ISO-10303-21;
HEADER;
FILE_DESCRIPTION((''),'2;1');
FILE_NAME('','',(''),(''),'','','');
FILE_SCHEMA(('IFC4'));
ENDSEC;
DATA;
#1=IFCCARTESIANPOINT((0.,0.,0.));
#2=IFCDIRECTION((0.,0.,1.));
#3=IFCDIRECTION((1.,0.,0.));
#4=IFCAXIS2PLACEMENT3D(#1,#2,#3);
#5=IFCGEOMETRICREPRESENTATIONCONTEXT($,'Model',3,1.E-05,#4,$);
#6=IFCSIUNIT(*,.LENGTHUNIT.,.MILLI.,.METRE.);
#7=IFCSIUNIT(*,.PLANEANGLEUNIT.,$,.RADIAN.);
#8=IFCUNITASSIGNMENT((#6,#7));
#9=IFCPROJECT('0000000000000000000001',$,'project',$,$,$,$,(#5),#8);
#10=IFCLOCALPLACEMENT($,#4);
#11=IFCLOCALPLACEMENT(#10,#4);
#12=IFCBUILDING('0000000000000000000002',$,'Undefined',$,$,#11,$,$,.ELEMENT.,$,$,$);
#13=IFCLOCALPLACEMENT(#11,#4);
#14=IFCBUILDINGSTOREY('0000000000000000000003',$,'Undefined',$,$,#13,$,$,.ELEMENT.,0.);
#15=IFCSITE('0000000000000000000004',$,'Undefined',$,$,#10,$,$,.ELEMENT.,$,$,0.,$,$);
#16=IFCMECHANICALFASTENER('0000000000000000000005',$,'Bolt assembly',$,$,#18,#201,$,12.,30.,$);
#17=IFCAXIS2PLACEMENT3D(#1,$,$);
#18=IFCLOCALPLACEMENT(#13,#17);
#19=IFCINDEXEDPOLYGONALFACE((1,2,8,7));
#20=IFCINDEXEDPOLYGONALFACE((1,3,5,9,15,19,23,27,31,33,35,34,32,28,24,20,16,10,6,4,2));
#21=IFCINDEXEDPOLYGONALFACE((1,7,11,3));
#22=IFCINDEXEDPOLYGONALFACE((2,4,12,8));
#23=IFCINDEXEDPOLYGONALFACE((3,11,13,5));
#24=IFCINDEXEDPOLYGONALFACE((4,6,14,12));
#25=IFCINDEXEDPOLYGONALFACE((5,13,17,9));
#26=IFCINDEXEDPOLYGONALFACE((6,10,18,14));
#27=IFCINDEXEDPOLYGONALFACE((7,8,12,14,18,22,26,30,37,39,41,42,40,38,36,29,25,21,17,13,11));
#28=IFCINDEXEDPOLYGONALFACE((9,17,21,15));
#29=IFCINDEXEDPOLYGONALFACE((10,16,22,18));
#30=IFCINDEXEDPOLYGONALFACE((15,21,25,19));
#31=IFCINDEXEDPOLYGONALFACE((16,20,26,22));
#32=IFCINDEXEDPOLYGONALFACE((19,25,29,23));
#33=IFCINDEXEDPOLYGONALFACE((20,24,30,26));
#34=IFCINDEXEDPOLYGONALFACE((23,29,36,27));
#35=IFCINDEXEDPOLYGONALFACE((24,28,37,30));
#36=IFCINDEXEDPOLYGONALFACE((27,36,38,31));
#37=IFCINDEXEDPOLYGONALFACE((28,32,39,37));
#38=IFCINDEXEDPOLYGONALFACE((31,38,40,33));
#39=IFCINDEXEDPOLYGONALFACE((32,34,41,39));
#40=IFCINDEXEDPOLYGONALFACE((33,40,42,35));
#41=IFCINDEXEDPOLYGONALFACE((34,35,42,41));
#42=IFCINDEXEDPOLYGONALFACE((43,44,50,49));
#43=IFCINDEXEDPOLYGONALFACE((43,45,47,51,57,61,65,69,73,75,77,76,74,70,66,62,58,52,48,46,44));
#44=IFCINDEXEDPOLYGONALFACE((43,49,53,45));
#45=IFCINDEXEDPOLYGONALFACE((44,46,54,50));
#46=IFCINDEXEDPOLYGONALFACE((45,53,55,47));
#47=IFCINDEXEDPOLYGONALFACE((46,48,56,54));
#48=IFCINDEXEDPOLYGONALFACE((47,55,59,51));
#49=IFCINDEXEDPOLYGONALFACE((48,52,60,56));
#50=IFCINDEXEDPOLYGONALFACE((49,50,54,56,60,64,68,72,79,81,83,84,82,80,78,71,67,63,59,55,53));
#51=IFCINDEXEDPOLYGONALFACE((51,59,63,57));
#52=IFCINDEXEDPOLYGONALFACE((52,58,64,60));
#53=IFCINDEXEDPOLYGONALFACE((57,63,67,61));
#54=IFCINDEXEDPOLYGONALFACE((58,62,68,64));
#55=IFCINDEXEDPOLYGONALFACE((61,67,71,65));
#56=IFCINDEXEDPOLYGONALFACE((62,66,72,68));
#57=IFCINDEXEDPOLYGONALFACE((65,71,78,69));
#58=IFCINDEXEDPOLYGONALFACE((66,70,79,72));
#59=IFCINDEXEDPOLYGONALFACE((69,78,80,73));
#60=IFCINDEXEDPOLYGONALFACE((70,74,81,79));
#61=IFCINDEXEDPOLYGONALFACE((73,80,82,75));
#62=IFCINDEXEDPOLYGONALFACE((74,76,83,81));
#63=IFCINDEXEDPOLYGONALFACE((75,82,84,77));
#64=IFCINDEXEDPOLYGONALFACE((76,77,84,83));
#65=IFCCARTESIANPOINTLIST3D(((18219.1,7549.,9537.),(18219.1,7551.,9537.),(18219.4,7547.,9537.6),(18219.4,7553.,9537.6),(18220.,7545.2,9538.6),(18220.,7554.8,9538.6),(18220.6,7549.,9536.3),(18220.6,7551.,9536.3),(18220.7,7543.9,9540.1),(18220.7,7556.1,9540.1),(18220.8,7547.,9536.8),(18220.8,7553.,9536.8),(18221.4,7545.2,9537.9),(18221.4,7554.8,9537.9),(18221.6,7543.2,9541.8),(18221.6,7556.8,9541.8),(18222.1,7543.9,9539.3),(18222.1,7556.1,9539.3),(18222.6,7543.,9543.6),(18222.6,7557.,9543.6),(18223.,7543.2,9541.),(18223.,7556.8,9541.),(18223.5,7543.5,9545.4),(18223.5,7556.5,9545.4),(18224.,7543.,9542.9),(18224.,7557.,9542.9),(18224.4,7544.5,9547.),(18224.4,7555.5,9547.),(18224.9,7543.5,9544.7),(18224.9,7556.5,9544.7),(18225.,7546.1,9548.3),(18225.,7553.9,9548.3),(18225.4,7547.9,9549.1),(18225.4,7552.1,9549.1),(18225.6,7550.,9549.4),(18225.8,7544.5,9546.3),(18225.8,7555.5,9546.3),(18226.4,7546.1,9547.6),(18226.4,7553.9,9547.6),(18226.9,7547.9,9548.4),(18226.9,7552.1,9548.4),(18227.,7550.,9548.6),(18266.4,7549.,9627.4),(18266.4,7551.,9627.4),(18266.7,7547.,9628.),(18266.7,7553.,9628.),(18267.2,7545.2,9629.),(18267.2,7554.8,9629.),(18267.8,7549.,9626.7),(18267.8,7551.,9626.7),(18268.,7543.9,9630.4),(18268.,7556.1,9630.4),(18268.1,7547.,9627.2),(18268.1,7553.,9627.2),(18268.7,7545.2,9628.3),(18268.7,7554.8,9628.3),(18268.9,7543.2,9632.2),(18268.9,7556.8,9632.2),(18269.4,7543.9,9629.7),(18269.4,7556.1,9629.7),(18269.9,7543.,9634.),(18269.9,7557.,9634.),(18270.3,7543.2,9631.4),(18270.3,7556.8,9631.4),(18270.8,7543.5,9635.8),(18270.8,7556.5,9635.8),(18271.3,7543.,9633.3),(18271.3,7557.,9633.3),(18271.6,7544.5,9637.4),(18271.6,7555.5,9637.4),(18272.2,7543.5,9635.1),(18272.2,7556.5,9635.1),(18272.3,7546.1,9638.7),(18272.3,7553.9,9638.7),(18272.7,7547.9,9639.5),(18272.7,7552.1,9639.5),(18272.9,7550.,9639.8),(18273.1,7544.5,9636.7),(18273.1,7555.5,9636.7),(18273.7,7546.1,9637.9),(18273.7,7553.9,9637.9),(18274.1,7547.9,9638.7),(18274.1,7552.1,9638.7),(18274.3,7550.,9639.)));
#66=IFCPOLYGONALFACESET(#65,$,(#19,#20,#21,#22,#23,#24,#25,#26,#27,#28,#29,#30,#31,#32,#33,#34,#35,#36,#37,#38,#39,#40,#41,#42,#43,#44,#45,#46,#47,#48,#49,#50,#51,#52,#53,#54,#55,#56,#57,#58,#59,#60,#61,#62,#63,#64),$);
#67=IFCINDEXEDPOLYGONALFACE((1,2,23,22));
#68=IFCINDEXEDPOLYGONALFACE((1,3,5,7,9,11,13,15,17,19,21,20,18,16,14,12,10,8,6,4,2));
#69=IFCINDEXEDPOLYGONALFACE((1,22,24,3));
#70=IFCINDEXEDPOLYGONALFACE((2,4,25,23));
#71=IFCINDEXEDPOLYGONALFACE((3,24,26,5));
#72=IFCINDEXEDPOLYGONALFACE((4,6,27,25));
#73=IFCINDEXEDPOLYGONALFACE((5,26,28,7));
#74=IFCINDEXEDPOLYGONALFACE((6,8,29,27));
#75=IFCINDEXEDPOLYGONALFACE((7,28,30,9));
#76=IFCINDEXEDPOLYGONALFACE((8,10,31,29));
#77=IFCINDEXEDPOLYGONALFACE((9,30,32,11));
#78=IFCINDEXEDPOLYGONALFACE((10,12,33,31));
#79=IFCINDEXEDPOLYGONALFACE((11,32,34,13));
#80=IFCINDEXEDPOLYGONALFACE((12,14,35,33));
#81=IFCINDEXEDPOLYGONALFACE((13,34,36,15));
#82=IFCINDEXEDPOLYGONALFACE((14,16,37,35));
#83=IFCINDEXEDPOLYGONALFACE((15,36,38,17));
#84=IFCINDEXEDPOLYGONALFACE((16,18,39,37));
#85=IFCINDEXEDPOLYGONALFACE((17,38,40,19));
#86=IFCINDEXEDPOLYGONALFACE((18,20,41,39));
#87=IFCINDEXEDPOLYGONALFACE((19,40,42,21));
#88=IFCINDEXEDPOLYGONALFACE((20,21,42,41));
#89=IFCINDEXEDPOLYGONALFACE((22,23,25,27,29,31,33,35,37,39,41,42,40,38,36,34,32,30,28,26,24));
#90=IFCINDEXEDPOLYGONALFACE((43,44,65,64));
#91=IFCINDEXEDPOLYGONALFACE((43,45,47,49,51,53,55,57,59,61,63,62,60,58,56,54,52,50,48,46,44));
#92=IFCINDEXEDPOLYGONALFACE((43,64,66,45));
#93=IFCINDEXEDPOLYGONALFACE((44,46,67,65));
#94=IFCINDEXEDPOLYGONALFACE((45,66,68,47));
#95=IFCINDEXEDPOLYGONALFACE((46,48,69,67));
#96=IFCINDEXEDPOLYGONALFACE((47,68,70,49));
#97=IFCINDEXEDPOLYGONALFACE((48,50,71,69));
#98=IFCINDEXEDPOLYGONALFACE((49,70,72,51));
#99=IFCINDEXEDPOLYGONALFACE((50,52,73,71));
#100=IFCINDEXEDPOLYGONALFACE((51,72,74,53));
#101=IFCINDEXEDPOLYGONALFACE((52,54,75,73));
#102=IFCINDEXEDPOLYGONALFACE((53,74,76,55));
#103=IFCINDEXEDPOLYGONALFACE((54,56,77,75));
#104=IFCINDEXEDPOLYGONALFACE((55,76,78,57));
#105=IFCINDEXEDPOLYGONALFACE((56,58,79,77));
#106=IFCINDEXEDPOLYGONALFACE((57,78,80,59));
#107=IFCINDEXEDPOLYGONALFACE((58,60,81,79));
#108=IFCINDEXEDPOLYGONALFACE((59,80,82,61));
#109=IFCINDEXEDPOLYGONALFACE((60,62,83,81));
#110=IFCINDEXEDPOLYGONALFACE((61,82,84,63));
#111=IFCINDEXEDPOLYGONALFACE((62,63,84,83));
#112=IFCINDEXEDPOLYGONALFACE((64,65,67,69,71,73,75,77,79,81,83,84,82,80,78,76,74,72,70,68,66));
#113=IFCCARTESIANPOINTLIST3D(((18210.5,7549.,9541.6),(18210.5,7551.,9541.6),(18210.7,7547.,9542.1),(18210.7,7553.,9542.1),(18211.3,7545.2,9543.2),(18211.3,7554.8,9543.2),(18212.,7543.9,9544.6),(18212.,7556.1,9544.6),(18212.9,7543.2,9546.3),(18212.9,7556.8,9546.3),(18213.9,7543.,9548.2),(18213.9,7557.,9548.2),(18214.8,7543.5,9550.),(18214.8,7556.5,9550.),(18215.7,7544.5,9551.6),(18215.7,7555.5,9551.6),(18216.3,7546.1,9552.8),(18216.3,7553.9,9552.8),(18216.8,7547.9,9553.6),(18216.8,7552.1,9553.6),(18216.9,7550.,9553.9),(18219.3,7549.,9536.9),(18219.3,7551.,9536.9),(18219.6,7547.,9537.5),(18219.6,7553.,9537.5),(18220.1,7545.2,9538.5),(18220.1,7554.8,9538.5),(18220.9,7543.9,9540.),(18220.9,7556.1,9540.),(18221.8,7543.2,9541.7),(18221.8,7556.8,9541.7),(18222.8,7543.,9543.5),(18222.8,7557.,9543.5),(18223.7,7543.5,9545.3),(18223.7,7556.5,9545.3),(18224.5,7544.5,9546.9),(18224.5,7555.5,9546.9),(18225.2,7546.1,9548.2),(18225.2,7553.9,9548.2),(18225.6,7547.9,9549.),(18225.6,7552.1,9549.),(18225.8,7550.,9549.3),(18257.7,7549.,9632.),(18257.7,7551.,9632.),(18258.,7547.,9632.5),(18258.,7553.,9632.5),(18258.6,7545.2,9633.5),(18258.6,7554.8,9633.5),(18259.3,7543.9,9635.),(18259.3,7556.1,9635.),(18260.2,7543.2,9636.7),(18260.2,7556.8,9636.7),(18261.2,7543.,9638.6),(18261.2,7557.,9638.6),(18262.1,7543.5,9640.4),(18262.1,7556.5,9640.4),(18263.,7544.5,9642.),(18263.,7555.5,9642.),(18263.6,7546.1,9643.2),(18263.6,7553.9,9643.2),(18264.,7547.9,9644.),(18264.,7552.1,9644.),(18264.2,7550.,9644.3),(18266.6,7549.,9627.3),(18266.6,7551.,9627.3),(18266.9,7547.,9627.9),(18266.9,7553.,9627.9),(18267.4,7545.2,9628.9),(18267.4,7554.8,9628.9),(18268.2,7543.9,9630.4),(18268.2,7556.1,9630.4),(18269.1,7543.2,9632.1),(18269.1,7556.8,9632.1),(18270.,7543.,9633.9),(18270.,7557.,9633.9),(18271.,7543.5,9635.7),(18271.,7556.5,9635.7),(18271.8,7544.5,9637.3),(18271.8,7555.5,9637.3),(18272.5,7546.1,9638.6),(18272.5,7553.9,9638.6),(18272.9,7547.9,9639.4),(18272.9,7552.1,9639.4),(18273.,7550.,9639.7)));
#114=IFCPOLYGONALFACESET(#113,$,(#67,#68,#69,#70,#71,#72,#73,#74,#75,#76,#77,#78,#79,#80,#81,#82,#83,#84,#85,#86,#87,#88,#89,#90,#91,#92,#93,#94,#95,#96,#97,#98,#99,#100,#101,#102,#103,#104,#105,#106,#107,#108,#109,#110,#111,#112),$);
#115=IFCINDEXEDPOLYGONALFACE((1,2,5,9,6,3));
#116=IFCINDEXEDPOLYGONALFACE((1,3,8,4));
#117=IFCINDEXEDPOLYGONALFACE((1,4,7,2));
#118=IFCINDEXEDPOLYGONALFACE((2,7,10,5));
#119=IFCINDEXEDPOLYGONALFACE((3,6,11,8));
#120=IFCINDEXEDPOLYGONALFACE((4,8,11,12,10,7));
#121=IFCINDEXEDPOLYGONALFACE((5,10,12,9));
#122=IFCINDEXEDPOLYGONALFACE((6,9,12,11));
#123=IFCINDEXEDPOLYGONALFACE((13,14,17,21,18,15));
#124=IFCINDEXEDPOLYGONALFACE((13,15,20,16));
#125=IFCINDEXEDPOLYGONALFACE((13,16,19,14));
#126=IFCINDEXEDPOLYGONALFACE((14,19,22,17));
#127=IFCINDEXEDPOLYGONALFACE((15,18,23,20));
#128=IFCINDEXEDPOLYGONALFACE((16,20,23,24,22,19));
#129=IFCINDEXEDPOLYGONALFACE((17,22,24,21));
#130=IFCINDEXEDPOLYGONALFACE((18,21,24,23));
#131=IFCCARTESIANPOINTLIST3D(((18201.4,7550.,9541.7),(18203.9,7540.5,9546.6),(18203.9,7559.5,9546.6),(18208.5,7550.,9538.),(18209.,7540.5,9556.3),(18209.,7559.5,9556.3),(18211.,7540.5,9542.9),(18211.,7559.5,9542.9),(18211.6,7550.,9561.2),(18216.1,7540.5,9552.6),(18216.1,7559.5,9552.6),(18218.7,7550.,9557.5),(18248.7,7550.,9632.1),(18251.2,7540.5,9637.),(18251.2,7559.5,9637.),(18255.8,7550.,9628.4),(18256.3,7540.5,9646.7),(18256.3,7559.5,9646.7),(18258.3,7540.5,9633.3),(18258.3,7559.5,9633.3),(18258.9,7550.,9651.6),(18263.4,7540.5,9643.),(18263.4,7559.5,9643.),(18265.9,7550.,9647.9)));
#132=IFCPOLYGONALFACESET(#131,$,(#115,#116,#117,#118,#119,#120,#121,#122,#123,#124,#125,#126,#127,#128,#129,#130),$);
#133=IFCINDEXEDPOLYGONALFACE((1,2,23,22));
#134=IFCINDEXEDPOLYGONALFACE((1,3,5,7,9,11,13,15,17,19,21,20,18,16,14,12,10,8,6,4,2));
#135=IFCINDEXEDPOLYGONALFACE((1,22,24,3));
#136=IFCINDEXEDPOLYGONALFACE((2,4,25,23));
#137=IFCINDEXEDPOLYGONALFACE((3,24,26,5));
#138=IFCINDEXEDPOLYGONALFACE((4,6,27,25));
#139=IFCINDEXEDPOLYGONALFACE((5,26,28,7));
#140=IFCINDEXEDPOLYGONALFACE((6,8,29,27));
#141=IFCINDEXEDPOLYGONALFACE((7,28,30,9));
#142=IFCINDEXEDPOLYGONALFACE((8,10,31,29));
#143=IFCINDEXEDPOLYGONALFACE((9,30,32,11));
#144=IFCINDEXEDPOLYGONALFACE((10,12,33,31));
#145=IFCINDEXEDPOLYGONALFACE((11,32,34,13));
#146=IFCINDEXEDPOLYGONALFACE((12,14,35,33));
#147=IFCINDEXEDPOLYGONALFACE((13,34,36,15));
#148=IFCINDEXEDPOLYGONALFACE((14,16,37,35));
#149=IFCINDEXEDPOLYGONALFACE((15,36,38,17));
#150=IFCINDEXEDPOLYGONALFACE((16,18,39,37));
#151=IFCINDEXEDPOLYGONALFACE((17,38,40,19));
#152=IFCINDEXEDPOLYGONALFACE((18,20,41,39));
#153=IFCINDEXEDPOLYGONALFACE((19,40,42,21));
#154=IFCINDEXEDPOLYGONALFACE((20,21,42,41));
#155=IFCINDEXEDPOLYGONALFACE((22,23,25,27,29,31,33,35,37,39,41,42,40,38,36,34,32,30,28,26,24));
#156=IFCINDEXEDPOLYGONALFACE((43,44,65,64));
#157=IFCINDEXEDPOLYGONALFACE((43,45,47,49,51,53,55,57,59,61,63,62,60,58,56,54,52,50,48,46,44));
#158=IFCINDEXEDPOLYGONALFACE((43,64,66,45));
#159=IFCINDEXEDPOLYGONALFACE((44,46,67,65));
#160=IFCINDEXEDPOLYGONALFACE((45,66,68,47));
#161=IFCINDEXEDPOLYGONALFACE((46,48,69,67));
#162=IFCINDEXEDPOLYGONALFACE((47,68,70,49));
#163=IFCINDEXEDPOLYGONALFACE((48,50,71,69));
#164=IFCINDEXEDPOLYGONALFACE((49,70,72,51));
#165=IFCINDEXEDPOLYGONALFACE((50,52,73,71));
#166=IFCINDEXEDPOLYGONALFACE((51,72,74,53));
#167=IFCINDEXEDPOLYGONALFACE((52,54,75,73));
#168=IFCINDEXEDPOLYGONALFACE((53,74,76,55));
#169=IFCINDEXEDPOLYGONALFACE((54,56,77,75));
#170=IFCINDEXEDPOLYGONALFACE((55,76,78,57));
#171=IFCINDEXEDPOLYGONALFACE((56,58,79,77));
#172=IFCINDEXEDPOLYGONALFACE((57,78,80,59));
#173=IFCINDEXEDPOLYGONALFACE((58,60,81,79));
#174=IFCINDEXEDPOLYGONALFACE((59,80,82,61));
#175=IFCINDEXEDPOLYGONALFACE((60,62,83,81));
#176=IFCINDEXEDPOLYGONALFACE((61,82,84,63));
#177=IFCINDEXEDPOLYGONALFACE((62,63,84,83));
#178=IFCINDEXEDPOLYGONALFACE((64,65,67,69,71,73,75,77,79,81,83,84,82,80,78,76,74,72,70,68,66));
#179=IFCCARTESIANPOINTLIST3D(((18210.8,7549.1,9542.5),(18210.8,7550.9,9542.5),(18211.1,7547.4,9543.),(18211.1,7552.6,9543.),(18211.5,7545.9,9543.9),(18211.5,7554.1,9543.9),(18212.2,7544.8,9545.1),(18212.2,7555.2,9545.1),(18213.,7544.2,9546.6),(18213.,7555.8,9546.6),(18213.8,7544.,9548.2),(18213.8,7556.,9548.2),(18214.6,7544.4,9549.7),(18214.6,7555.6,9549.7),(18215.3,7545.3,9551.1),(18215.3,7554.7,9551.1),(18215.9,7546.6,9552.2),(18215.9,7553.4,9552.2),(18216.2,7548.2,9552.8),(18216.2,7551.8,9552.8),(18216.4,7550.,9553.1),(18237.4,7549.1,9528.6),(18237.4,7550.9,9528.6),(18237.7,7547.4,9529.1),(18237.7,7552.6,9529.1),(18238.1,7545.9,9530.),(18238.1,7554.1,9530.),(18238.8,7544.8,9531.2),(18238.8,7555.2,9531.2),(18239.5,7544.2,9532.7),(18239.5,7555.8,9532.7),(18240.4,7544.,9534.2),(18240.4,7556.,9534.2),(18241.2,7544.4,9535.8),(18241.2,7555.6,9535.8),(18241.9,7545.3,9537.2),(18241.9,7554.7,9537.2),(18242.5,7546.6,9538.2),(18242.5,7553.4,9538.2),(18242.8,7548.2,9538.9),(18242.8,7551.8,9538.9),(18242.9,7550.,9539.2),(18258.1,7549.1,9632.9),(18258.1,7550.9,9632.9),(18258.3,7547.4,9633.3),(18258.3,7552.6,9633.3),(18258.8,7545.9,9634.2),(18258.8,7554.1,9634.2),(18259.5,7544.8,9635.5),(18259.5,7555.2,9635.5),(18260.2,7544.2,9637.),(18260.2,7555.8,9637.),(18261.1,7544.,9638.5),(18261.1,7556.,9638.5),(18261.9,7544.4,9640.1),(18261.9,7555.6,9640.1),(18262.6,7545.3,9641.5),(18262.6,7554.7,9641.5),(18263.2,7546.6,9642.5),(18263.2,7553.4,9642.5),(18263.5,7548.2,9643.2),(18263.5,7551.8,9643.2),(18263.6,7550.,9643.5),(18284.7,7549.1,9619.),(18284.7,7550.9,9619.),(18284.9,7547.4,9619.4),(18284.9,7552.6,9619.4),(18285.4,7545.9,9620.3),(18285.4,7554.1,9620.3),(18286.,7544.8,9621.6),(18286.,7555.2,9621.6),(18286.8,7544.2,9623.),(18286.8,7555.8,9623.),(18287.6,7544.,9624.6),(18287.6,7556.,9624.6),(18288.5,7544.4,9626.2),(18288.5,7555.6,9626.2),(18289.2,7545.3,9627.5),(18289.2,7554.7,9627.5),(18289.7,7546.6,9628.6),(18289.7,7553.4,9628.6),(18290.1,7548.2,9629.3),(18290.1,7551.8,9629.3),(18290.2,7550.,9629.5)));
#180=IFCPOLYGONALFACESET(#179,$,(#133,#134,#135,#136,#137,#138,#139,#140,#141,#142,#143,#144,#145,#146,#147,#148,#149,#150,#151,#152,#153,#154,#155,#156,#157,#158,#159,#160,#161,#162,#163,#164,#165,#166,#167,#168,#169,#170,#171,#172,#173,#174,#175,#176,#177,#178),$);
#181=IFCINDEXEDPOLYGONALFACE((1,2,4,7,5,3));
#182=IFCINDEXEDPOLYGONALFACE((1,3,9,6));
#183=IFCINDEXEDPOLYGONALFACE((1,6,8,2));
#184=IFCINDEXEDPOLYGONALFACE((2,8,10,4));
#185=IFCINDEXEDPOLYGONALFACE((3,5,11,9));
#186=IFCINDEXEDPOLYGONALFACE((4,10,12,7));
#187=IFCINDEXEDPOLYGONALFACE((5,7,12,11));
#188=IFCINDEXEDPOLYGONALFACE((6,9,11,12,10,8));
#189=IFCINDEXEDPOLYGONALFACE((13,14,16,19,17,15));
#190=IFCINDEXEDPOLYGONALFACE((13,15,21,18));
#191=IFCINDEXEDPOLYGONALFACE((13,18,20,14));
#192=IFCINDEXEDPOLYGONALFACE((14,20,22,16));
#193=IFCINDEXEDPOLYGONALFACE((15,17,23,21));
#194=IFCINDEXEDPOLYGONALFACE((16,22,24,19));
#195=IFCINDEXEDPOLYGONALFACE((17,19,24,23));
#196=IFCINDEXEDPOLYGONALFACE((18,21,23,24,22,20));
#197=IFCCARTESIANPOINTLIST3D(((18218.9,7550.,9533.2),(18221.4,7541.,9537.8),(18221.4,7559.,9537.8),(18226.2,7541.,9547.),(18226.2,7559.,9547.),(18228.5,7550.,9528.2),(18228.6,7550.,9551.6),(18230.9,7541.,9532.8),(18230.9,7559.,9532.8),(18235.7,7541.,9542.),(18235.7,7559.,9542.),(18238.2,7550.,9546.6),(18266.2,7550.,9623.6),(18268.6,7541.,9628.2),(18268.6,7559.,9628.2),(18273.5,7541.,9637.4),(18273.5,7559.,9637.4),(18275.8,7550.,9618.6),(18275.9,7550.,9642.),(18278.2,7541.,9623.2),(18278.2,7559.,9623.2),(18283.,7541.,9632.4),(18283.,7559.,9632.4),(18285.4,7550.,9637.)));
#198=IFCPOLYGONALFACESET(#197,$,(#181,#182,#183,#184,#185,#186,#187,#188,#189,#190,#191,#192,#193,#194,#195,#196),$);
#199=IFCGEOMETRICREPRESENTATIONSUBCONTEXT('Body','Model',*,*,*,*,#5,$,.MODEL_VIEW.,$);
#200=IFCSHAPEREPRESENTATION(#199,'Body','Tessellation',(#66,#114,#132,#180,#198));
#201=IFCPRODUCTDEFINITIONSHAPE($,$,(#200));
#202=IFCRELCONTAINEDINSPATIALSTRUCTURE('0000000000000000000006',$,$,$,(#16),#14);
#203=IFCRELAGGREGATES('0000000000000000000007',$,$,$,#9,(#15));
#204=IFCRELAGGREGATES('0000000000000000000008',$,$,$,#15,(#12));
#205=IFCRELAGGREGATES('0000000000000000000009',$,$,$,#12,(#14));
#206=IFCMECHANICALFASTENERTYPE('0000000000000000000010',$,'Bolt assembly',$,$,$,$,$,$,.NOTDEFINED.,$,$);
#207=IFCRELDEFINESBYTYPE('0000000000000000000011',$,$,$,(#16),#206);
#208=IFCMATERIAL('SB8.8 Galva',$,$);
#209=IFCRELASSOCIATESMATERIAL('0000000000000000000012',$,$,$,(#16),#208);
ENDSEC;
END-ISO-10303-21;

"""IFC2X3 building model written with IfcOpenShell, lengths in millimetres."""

from ifc_helpers import new_model, si_unit, frame, origin_with_axes, origin_2d_with_axis, place, context, subcontext, project, spatial, polyline, circle, outline, extrude, source, transform, mapped, material, type_object, element, save


model = new_model("IFC2X3")

# Units and contexts
model_context = context("Model", 3, precision=1e-05, world=origin_with_axes())
body_context = subcontext(model_context, "Body", "Model", "MODEL_VIEW")
ifc_project = project(units=[si_unit("LENGTHUNIT", "METRE", prefix="MILLI"), si_unit("PLANEANGLEUNIT", "RADIAN")], contexts=[model_context])

# Site, building, storey
site_placement = place(None, origin_with_axes())
site = spatial("IfcSite", under=ifc_project, at=site_placement, Name="Undefined", CompositionType="ELEMENT", RefElevation=0.0)
building_placement = place(site_placement, origin_with_axes())
building = spatial("IfcBuilding", under=site, at=building_placement, Name="Undefined", CompositionType="ELEMENT")
storey_placement = place(building_placement, origin_with_axes())
storey = spatial("IfcBuildingStorey", under=building, at=storey_placement, Name="Undefined", CompositionType="ELEMENT", Elevation=0.0)

# Mechanical fastener
mechanical_fastener_type = type_object("IfcMechanicalFastenerType", Name="Bolt assembly")
ifc_material_1 = material(Name="SB8.8 Galva")
shared_shape_1 = source(origin_with_axes(), body_context, "Body", "SweptSolid", [
    extrude(circle(Radius=7.0, at=origin_2d_with_axis()), frame((0.0, -0.1, 0.0), z_axis=(0.0, 1.0, 0.0), x_axis=(1.0, 0.0, 0.0)), (0.0, 0.0, 1.0), 1.6),
    extrude(circle(Radius=7.0, at=origin_2d_with_axis()), frame((0.0, -9.9, 0.0), z_axis=(0.0, 1.0, 0.0), x_axis=(1.0, 0.0, 0.0)), (0.0, 0.0, 1.0), 10.0),
    extrude(outline(polyline([(11.0, 0.0), (5.5, 9.5), (-5.5, 9.5), (-11.0, 0.0), (-5.5, -9.5), (5.5, -9.5), (11.0, 0.0)])), frame((0.0, -18.0, 0.0), z_axis=(0.0, 1.0, 0.0), x_axis=(1.0, 0.0, 0.0)), (0.0, 0.0, 1.0), 8.0),
    extrude(circle(Radius=6.0, at=origin_2d_with_axis()), frame((0.0, -10.0, 0.0), z_axis=(0.0, 1.0, 0.0), x_axis=(1.0, 0.0, 0.0)), (0.0, 0.0, 1.0), 30.0),
    extrude(outline(polyline([(10.4, 0.0), (5.2, 9.0), (-5.2, 9.0), (-10.4, 0.0), (-5.2, -9.0), (5.2, -9.0), (10.4, 0.0)])), frame((0.0, 1.5, 0.0), z_axis=(0.0, 1.0, 0.0), x_axis=(1.0, 0.0, 0.0)), (0.0, 0.0, 1.0), 10.8),
])
for number, where, z_axis, x_axis, name in (
    (1, (18222.4, 7550.0, 9543.1), (0.0, 1.0, 0.0), (0.463529, 0.0, 0.886082), "Bolt assembly"),
):
    element("IfcMechanicalFastener", number, at=place(storey_placement, frame(where, z_axis=z_axis, x_axis=x_axis)), inside=storey, type_object=mechanical_fastener_type, material=ifc_material_1, Name=name, NominalDiameter=12.0, NominalLength=30.0, context=body_context, shape_type="MappedRepresentation", body=[
        mapped(shared_shape_1, transform((0.0, 0.0, 0.0))),
        mapped(shared_shape_1, transform((102.0, 0.0, 0.0))),
    ])

save(model, "model.ifc")
